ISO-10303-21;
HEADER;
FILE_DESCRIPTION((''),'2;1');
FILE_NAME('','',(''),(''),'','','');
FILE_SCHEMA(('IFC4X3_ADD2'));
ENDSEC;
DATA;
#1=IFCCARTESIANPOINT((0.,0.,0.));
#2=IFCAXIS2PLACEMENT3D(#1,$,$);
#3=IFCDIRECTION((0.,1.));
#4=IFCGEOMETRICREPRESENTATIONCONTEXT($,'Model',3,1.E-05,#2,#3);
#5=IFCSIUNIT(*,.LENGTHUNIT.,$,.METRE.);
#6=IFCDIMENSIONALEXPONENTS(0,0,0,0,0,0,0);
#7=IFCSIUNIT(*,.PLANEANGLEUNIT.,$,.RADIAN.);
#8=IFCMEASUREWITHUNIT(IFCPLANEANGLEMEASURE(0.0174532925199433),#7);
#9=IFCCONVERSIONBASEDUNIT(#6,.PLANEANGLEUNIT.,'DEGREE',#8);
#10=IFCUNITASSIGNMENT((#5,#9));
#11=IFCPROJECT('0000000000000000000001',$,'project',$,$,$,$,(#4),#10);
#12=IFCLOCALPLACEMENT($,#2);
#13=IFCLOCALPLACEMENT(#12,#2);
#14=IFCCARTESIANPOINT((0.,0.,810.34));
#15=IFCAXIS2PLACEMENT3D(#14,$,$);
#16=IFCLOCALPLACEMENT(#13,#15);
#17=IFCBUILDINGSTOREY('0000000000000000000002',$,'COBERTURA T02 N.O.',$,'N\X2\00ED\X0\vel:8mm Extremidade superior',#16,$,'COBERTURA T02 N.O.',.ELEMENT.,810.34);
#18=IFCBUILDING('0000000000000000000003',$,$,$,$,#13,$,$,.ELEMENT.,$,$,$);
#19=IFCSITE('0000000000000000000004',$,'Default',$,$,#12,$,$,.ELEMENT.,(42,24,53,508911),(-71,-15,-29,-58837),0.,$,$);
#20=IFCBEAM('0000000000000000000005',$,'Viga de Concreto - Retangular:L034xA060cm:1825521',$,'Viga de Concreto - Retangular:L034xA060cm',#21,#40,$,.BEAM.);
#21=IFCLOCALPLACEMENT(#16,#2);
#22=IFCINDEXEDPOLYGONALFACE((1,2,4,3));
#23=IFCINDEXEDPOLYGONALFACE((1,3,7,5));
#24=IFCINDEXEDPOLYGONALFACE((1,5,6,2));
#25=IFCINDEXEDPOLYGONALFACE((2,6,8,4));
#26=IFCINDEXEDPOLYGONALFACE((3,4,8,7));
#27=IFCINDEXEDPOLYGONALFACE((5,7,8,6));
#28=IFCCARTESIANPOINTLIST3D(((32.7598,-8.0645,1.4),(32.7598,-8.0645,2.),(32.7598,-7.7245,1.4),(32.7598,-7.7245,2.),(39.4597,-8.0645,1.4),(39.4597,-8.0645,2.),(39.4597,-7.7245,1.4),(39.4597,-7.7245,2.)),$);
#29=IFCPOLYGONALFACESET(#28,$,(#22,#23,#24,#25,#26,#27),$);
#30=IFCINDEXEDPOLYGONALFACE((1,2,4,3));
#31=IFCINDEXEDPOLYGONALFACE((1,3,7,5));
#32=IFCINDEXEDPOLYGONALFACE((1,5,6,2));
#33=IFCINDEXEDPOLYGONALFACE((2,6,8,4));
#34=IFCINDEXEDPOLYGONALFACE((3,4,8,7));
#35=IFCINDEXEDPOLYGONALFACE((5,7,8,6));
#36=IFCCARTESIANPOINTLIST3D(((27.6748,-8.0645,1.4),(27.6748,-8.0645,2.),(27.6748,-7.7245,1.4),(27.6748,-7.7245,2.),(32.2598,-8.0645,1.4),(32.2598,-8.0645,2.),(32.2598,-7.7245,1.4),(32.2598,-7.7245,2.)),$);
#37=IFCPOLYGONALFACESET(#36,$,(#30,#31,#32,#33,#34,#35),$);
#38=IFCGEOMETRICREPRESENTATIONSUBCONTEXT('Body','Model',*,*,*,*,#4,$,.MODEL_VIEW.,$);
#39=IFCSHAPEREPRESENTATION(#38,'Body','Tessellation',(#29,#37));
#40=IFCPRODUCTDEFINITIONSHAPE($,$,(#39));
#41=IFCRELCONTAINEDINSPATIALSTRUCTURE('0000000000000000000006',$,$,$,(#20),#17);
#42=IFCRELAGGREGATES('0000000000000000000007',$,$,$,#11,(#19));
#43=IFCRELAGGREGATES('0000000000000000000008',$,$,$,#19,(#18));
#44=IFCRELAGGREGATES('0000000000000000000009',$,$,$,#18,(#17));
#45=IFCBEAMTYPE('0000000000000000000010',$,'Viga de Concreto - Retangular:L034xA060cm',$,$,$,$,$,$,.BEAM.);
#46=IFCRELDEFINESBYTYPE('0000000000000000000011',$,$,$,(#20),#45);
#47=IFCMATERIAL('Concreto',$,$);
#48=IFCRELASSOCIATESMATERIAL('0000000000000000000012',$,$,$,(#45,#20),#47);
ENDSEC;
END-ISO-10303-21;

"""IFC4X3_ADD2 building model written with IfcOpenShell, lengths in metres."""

from ifc_helpers import new_model, entity, si_unit, converted_unit, direction, frame, frame_2d, origin, place, context, subcontext, project, spatial, polyline, segment, composite_curve, rectangle, outline, extrude, source, transform, mapped, material, material_profile, profile_set, profile_usage, type_object, type_shapes, element, save


model = new_model("IFC4X3_ADD2")

# Units and contexts
model_context = context("Model", 3, precision=1e-05, world=origin(), true_north=direction((0.0, 1.0)))
body_context = subcontext(model_context, "Body", "Model", "MODEL_VIEW")
ifc_project = project(units=[si_unit("LENGTHUNIT", "METRE"), converted_unit("PLANEANGLEUNIT", "DEGREE", entity("IfcPlaneAngleMeasure", 0.0174532925199433), si_unit("PLANEANGLEUNIT", "RADIAN"), dimensions=[0, 0, 0, 0, 0, 0, 0])], contexts=[model_context])

# Site, building, storey
site_placement = place(None, origin())
site = spatial("IfcSite", under=ifc_project, at=site_placement, Name="Default", CompositionType="ELEMENT", RefLatitude=(42, 24, 53, 508911), RefLongitude=(-71, -15, -29, -58837), RefElevation=0.0)
building_placement = place(site_placement, origin())
building = spatial("IfcBuilding", under=site, at=building_placement, CompositionType="ELEMENT")
storey_placement = place(building_placement, frame((0.0, 0.0, 810.34)))
storey = spatial("IfcBuildingStorey", under=building, at=storey_placement, Name="COBERTURA T02 N.O.", ObjectType="Nível:8mm Extremidade superior", LongName="COBERTURA T02 N.O.", CompositionType="ELEMENT", Elevation=810.34)

# Shared definitions
ifc_material = material(Name="Concreto")

# Beam
ifc_material_profile_1 = material_profile(ifc_material, outline(composite_curve([segment(polyline([(-0.17, 0.3, 0.0), (0.17, 0.3, 0.0)]), True, "CONTINUOUS"), segment(polyline([(0.17, 0.3, 0.0), (0.17, -0.3, 0.0)]), True, "CONTINUOUS"), segment(polyline([(0.17, -0.3, 0.0), (-0.17, -0.3, 0.0)]), True, "CONTINUOUS"), segment(polyline([(-0.17, -0.3, 0.0), (-0.17, 0.3, 0.0)]), True, "CONTINUOUS")], self_intersect=False), kind="CURVE"), Name="L034xA060cm")
ifc_material_profile_2 = material_profile(ifc_material, outline(composite_curve([segment(polyline([(-2.2925, 0.17, 0.3), (-2.2925, 0.17, -0.3)]), True, "CONTINUOUS"), segment(polyline([(-2.2925, 0.17, -0.3), (-2.2925, -0.17, -0.3)]), True, "CONTINUOUS"), segment(polyline([(-2.2925, -0.17, -0.3), (-2.2925, -0.17, 0.3)]), True, "CONTINUOUS"), segment(polyline([(-2.2925, -0.17, 0.3), (-2.2925, 0.17, 0.3)]), True, "CONTINUOUS")], self_intersect=False), kind="CURVE"), Name="L034xA060cm")
ifc_profile_set_1 = profile_set([ifc_material_profile_1, ifc_material_profile_2], Name="L034xA060cm")
ifc_profile_usage_1 = profile_usage(ifc_profile_set_1, cardinal=8)
beam_type_1 = type_object("IfcBeamType", Name="Viga de Concreto - Retangular:L034xA060cm", PredefinedType="BEAM", material=ifc_profile_set_1)
shared_shape_1 = source(origin(), body_context, "Body", "SweptSolid", [
    extrude(rectangle(XDim=0.6, YDim=0.34, at=frame_2d((0.0, 0.0), x_axis=(1.0, 0.0))), frame((32.7598, -7.8945, 812.04), z_axis=(1.0, 0.0, 0.0), x_axis=(0.0, 0.0, -1.0)), (0.0, 0.0, 1.0), 6.6999),
    extrude(rectangle(XDim=0.6, YDim=0.34, at=frame_2d((0.0, 0.0), x_axis=(1.0, 0.0))), frame((27.6748, -7.8945, 812.04), z_axis=(1.0, 0.0, 0.0), x_axis=(0.0, 0.0, -1.0)), (0.0, 0.0, 1.0), 4.585),
])
type_shapes(beam_type_1, [shared_shape_1])
beam_1_placement = place(storey_placement, frame((0.0, 0.0, -810.34)))
element("IfcBeam", 1, at=beam_1_placement, inside=storey, type_object=beam_type_1, material=ifc_profile_usage_1, Name="Viga de Concreto - Retangular:L034xA060cm:1825521", ObjectType="Viga de Concreto - Retangular:L034xA060cm", PredefinedType="BEAM", context=body_context, shape_type="MappedRepresentation", body=[
    mapped(shared_shape_1, transform((0.0, 0.0, 0.0), scale=1.0)),
])

save(model, "model.ifc")
